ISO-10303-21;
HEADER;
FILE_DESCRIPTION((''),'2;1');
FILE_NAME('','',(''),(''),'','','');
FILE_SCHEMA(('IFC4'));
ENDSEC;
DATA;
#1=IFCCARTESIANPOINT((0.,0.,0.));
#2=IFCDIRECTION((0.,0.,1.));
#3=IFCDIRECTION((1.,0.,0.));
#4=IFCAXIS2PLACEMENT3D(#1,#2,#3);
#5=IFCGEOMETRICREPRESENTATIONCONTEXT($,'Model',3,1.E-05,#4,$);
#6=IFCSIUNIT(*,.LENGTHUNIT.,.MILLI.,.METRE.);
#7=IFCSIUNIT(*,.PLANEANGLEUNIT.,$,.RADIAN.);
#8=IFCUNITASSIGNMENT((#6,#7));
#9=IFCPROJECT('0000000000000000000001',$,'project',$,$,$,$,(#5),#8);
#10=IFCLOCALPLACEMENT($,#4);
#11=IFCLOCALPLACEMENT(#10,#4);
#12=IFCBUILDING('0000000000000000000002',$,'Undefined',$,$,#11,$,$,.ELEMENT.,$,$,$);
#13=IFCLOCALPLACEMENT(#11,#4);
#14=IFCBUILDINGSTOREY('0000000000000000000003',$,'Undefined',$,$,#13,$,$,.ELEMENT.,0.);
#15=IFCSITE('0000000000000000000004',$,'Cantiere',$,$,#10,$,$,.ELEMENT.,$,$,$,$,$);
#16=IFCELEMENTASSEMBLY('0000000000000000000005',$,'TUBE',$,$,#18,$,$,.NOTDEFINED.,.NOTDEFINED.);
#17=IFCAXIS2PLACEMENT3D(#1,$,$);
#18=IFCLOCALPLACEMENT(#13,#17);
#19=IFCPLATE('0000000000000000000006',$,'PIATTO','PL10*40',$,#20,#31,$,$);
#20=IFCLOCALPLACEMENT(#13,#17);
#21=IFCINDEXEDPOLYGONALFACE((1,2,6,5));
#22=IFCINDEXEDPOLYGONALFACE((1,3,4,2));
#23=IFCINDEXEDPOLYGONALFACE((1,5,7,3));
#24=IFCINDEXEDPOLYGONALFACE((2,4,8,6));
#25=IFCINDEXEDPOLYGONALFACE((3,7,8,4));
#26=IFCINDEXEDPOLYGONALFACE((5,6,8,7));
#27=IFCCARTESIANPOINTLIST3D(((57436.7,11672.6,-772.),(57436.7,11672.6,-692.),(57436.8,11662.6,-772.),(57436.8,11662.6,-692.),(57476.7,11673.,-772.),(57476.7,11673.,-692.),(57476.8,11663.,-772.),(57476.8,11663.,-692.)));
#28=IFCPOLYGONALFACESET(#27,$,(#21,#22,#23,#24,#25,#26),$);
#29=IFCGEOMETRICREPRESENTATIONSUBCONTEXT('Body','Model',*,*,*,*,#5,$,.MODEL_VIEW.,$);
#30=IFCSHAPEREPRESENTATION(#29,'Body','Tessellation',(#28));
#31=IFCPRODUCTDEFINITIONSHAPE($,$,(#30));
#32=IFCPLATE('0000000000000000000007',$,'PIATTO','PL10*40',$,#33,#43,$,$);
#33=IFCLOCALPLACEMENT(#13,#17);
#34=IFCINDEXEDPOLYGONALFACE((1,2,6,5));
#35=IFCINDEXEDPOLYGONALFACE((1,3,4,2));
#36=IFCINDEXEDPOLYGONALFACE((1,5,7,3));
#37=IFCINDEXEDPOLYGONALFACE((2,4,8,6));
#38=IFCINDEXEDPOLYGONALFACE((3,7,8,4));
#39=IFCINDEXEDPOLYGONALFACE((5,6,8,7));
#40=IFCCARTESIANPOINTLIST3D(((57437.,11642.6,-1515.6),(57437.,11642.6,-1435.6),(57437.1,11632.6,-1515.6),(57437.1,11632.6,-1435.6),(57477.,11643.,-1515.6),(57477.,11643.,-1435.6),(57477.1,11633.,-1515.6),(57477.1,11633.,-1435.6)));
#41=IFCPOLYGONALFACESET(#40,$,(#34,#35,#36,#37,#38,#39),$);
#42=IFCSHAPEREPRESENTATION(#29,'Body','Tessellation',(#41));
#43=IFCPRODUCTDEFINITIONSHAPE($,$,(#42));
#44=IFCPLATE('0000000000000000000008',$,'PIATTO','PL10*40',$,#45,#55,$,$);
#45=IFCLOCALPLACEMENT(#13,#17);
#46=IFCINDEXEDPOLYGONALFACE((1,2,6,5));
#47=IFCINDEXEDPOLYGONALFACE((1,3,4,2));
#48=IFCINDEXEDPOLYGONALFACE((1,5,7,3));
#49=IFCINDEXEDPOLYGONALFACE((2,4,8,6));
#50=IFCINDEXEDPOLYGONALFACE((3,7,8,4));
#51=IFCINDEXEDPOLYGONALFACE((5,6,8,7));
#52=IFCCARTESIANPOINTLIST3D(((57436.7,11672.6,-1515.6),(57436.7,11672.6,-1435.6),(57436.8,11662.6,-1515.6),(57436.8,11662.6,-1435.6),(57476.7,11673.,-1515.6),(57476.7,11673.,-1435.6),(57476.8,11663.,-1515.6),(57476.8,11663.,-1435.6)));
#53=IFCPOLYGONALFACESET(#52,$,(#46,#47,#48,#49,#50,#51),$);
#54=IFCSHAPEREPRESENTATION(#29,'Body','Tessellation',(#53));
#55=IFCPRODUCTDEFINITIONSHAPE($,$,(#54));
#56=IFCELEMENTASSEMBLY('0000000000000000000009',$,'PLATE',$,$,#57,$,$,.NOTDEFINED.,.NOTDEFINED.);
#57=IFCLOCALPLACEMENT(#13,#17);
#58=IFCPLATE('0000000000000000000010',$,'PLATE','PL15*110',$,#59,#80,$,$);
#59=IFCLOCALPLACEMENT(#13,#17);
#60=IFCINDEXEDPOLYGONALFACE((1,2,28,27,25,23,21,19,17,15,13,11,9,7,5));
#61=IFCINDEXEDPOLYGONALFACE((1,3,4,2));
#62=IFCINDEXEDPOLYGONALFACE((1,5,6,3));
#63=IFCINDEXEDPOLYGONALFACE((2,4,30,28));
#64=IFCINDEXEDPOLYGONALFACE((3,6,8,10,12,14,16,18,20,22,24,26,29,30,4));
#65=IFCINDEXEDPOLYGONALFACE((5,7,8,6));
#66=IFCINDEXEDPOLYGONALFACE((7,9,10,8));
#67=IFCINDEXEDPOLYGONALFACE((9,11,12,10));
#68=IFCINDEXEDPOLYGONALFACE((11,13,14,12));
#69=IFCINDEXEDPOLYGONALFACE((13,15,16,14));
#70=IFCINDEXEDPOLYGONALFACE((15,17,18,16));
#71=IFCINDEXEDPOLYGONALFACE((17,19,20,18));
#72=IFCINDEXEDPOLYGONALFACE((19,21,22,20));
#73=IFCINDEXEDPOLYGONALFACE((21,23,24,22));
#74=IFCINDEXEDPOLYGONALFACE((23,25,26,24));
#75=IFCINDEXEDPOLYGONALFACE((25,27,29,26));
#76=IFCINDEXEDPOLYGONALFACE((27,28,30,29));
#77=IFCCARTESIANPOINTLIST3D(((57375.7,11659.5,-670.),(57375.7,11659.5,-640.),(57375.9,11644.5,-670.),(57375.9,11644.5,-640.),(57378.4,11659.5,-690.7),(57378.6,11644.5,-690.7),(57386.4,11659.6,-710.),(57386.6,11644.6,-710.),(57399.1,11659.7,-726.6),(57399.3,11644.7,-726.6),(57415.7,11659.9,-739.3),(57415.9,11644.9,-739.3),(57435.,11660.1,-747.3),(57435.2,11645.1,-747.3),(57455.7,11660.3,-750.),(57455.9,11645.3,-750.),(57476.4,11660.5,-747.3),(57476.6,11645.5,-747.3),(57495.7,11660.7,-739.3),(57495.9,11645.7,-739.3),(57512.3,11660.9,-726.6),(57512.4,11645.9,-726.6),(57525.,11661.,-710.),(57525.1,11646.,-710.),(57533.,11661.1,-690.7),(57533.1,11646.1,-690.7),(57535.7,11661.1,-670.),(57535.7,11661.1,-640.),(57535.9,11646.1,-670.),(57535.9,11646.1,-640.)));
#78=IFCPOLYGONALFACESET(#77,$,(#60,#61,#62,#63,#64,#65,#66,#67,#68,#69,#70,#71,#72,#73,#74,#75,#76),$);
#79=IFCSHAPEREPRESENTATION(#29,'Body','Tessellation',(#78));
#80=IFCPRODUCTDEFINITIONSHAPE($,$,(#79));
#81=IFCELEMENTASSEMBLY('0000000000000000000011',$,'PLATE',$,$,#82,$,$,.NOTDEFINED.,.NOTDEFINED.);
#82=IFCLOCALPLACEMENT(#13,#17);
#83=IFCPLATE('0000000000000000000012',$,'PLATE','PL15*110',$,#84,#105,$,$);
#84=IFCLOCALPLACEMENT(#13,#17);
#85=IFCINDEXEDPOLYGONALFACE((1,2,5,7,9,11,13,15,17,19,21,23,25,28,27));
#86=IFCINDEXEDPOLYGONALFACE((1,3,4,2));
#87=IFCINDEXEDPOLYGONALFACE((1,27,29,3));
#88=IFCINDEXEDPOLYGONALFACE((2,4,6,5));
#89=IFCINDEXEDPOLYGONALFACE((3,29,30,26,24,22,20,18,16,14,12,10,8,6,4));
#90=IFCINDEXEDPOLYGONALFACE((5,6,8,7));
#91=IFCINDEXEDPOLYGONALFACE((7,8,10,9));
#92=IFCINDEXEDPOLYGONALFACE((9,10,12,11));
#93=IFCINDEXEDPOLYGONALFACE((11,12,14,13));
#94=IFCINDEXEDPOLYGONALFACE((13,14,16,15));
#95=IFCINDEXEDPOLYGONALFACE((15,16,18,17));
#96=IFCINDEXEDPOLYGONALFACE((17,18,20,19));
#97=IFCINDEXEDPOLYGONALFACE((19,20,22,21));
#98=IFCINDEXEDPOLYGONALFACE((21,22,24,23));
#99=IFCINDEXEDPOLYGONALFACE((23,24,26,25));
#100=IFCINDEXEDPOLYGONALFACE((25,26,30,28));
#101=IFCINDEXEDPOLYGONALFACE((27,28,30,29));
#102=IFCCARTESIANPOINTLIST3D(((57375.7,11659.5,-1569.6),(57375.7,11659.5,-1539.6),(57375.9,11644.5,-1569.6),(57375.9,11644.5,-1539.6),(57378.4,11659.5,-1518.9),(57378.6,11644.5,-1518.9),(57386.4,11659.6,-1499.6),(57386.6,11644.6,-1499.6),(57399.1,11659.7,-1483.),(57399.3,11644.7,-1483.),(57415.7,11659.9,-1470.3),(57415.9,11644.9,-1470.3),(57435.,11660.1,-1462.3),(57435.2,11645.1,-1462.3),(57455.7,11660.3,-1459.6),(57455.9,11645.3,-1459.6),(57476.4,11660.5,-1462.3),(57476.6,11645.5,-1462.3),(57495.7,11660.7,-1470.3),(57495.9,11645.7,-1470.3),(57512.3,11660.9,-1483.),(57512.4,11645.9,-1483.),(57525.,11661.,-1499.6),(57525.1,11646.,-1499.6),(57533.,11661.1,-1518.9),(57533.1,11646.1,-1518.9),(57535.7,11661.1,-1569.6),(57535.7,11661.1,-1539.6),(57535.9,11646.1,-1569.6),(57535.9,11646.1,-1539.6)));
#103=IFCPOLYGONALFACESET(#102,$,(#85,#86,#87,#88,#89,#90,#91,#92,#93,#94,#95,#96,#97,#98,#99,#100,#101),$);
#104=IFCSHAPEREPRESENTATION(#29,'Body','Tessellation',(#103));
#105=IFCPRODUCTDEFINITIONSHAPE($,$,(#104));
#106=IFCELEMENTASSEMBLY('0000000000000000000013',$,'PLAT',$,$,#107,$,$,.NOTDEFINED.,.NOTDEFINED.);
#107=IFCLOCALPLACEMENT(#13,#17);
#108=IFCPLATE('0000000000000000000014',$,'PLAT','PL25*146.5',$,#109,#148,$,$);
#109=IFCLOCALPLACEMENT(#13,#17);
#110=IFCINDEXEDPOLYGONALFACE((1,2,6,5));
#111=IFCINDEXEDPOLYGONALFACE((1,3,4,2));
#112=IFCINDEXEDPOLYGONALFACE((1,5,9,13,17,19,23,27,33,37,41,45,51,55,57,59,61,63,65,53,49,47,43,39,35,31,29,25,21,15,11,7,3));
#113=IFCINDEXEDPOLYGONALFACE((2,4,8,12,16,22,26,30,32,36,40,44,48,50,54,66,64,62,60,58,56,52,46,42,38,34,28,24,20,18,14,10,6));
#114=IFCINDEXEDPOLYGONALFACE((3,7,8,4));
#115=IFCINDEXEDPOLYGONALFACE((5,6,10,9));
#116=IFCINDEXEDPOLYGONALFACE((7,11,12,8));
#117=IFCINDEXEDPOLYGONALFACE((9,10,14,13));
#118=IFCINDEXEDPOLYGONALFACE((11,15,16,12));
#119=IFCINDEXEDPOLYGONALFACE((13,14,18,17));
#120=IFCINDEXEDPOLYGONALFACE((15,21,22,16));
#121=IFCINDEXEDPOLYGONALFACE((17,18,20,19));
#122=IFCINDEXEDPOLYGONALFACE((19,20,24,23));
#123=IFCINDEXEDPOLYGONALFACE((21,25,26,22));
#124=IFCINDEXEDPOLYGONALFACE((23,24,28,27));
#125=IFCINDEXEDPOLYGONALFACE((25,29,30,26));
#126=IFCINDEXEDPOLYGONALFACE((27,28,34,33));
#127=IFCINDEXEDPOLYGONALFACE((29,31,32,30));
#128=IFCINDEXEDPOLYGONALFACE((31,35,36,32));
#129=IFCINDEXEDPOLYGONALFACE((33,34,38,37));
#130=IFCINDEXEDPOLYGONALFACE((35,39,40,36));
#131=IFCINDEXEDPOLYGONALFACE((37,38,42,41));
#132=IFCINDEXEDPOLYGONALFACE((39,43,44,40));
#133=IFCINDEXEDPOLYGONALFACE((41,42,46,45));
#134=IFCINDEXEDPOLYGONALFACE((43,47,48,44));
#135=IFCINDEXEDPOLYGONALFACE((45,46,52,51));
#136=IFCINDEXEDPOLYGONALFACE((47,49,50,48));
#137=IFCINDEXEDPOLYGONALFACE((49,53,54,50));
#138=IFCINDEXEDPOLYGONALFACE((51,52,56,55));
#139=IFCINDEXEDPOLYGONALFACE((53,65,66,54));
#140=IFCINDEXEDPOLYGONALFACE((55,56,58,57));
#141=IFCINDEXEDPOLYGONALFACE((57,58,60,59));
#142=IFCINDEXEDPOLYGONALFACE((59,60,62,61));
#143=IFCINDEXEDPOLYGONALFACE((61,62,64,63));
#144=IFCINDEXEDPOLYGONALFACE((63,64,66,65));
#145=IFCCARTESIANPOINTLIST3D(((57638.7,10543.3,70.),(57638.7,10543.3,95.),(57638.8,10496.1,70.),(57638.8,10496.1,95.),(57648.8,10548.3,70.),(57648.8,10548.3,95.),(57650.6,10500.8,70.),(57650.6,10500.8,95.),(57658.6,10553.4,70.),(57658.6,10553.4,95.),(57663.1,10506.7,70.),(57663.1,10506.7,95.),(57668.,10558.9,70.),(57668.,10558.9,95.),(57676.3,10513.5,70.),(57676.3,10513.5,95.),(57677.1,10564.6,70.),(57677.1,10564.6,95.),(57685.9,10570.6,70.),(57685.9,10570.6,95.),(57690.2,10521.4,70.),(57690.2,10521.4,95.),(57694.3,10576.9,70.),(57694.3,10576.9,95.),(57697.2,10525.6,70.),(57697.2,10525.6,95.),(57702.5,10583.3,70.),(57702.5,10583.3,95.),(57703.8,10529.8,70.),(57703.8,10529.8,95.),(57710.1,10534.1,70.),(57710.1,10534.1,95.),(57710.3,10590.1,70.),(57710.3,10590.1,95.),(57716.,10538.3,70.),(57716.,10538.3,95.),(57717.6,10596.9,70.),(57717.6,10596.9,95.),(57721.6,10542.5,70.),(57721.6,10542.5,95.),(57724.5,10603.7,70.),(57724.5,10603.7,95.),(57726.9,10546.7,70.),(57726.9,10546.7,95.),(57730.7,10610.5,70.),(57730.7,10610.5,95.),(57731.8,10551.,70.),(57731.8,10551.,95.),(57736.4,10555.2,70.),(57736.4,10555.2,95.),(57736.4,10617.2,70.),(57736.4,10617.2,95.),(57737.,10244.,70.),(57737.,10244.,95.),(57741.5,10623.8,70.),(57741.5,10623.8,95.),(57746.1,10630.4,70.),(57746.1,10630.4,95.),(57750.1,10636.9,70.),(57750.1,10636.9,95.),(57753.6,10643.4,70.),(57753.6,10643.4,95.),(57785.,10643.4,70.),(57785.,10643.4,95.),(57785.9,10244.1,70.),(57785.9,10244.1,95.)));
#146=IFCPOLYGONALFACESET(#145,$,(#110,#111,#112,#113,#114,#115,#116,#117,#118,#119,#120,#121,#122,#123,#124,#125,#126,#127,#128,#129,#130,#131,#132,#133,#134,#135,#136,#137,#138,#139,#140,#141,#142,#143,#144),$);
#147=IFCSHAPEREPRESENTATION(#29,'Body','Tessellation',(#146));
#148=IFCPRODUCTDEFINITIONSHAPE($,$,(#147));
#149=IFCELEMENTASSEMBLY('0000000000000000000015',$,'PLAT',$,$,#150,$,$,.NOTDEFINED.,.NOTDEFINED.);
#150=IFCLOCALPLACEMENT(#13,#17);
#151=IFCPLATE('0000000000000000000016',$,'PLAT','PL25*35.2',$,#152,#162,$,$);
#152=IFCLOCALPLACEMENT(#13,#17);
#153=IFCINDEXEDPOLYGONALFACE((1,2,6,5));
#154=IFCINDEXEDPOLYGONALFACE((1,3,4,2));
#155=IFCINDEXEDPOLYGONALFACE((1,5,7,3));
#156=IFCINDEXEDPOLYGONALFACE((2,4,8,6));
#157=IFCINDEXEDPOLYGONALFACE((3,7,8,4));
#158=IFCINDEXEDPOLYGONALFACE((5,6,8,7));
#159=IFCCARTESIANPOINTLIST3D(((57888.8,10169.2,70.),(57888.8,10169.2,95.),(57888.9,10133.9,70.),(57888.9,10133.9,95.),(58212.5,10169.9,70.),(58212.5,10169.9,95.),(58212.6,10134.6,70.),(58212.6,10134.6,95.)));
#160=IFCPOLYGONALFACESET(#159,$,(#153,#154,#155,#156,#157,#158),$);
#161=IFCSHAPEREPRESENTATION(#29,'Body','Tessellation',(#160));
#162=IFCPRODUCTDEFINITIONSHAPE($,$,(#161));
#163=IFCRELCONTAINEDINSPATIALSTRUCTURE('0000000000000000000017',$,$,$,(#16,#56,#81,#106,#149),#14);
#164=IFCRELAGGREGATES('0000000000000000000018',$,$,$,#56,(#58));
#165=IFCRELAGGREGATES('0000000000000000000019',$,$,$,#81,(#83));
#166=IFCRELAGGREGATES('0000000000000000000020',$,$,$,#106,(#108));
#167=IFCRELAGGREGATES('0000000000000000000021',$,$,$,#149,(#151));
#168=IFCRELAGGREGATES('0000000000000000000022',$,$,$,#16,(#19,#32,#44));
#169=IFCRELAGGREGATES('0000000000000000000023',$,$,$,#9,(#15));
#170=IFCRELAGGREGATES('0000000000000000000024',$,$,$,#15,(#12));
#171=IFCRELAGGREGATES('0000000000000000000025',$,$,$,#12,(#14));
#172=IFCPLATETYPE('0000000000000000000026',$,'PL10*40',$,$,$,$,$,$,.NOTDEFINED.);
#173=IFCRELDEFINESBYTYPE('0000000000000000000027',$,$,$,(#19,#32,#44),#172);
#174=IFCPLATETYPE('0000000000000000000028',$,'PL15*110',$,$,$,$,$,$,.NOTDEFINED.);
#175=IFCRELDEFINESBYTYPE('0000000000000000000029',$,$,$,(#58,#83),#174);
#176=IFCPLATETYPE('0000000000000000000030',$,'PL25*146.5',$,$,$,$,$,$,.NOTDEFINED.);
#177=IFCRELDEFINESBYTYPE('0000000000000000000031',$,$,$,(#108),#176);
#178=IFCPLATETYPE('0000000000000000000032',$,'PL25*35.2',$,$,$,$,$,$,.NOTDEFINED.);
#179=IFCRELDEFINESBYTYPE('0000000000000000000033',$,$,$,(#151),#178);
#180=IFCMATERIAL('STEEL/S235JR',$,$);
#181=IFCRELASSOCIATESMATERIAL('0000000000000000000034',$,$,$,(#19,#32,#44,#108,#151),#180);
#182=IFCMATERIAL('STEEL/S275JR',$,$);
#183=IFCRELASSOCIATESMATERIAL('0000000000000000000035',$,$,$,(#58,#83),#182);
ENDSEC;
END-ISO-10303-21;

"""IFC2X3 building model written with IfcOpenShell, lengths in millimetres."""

from ifc_helpers import new_model, si_unit, frame, frame_2d, origin_with_axes, place, context, subcontext, project, spatial, polyline, circle_curve, parameter, trimmed, segment, composite_curve, outline, extrude, material, type_object, element, aggregate, save


model = new_model("IFC2X3")

# Units and contexts
model_context = context("Model", 3, precision=1e-05, world=origin_with_axes())
body_context = subcontext(model_context, "Body", "Model", "MODEL_VIEW")
ifc_project = project(units=[si_unit("LENGTHUNIT", "METRE", prefix="MILLI"), si_unit("PLANEANGLEUNIT", "RADIAN")], contexts=[model_context])

# Site, building, storey
site_placement = place(None, origin_with_axes())
site = spatial("IfcSite", under=ifc_project, at=site_placement, Name="Cantiere", CompositionType="ELEMENT")
building_placement = place(site_placement, origin_with_axes())
building = spatial("IfcBuilding", under=site, at=building_placement, Name="Undefined", CompositionType="ELEMENT")
storey_placement = place(building_placement, origin_with_axes())
storey = spatial("IfcBuildingStorey", under=building, at=storey_placement, Name="Undefined", CompositionType="ELEMENT", Elevation=0.0)

# Element assembly
assembly_1_placement = place(storey_placement, origin_with_axes())
assembly_1 = element("IfcElementAssembly", 1, at=assembly_1_placement, inside=storey, Name="TUBE", AssemblyPlace="NOTDEFINED", PredefinedType="NOTDEFINED")
ifc_material_1 = material(Name="STEEL/S235JR")

# Plates
plate_type_1 = type_object("IfcPlateType", Name="PL10*40", PredefinedType="NOTDEFINED")
plate_1_placement = place(assembly_1_placement, frame((57476.8, 11668.0, -772.0), z_axis=(0.01014, -0.999949, 0.0), x_axis=(0.0, 0.0, 1.0)))
plate_1 = element("IfcPlate", 2, at=plate_1_placement, type_object=plate_type_1, material=ifc_material_1, Name="PIATTO", Description="PL10*40", context=body_context, shape_type="SweptSolid", body=[
    extrude(outline(polyline([(0.0, 0.0), (80.0, 0.0), (80.0, 40.0), (0.0, 40.0), (0.0, 0.0)])), frame((0.0, 0.0, -5.0), z_axis=(0.0, 0.0, 1.0), x_axis=(1.0, 0.0, 0.0)), (0.0, 0.0, 1.0), 10.0),
])
plate_2_placement = place(assembly_1_placement, frame((57437.1, 11637.6, -1435.6), z_axis=(0.01014, -0.999949, 0.0), x_axis=(0.0, 0.000001, -1.0)))
plate_2 = element("IfcPlate", 3, at=plate_2_placement, type_object=plate_type_1, material=ifc_material_1, Name="PIATTO", Description="PL10*40", context=body_context, shape_type="SweptSolid", body=[
    extrude(outline(polyline([(0.0, 0.0), (80.0, 0.0), (80.0, 40.0), (0.0, 40.0), (0.0, 0.0)])), frame((0.0, 0.0, -5.0), z_axis=(0.0, 0.0, 1.0), x_axis=(1.0, 0.0, 0.0)), (0.0, 0.0, 1.0), 10.0),
])
plate_3_placement = place(assembly_1_placement, frame((57436.8, 11667.6, -1435.6), z_axis=(0.01014, -0.999949, 0.0), x_axis=(0.0, 0.000001, -1.0)))
plate_3 = element("IfcPlate", 4, at=plate_3_placement, type_object=plate_type_1, material=ifc_material_1, Name="PIATTO", Description="PL10*40", context=body_context, shape_type="SweptSolid", body=[
    extrude(outline(polyline([(0.0, 0.0), (80.0, 0.0), (80.0, 40.0), (0.0, 40.0), (0.0, 0.0)])), frame((0.0, 0.0, -5.0), z_axis=(0.0, 0.0, 1.0), x_axis=(1.0, 0.0, 0.0)), (0.0, 0.0, 1.0), 10.0),
])

# Element assemblies, plates
assembly_2_placement = place(storey_placement, origin_with_axes())
assembly_2 = element("IfcElementAssembly", 5, at=assembly_2_placement, inside=storey, Name="PLATE", AssemblyPlace="NOTDEFINED", PredefinedType="NOTDEFINED")
ifc_material_2 = material(Name="STEEL/S275JR")
plate_type_2 = type_object("IfcPlateType", Name="PL15*110", PredefinedType="NOTDEFINED")
plate_4_placement = place(assembly_2_placement, frame((57375.8, 11652.0, -640.0), z_axis=(-0.010139, 0.999949, 0.0), x_axis=(0.999949, 0.010139, 0.0)))
plate_4 = element("IfcPlate", 6, at=plate_4_placement, type_object=plate_type_2, material=ifc_material_2, Name="PLATE", Description="PL15*110", context=body_context, shape_type="SweptSolid", body=[
    extrude(outline(composite_curve([segment(polyline([(0.0, 0.0), (160.0, 0.0), (160.0, 30.0)]), True, "CONTINUOUS"), segment(trimmed(circle_curve(frame_2d((80.0, 30.0), x_axis=(1.0, 0.0)), 80.0), [parameter(0.0)], [parameter(1.570796)], True, "PARAMETER"), True, "CONTINUOUS"), segment(trimmed(circle_curve(frame_2d((80.0, 30.0), x_axis=(0.0, 1.0)), 80.0), [parameter(0.0)], [parameter(1.570796)], True, "PARAMETER"), True, "CONTINUOUS"), segment(polyline([(0.0, 30.0), (0.0, 0.0)]), True, "CONTINUOUS")], self_intersect=True)), frame((0.0, 0.0, -7.5), z_axis=(0.0, 0.0, 1.0), x_axis=(1.0, 0.0, 0.0)), (0.0, 0.0, 1.0), 15.0),
])
aggregate(assembly_2, [plate_4])
assembly_3_placement = place(storey_placement, origin_with_axes())
assembly_3 = element("IfcElementAssembly", 7, at=assembly_3_placement, inside=storey, Name="PLATE", AssemblyPlace="NOTDEFINED", PredefinedType="NOTDEFINED")
plate_5_placement = place(assembly_3_placement, frame((57375.8, 11652.0, -1569.6), z_axis=(0.010138, -0.999949, 0.0), x_axis=(0.999949, 0.010139, 0.0)))
plate_5 = element("IfcPlate", 8, at=plate_5_placement, type_object=plate_type_2, material=ifc_material_2, Name="PLATE", Description="PL15*110", context=body_context, shape_type="SweptSolid", body=[
    extrude(outline(composite_curve([segment(polyline([(0.0, 0.0), (160.0, 0.0), (160.0, 30.0)]), True, "CONTINUOUS"), segment(trimmed(circle_curve(frame_2d((80.0, 30.0), x_axis=(1.0, 0.0)), 80.0), [parameter(0.0)], [parameter(1.570796)], True, "PARAMETER"), True, "CONTINUOUS"), segment(trimmed(circle_curve(frame_2d((80.0, 30.0), x_axis=(0.0, 1.0)), 80.0), [parameter(0.0)], [parameter(1.570796)], True, "PARAMETER"), True, "CONTINUOUS"), segment(polyline([(0.0, 30.0), (0.0, 0.0)]), True, "CONTINUOUS")], self_intersect=True)), frame((0.0, 0.0, -7.5), z_axis=(0.0, 0.0, 1.0), x_axis=(1.0, 0.0, 0.0)), (0.0, 0.0, 1.0), 15.0),
])
aggregate(assembly_3, [plate_5])
assembly_4_placement = place(storey_placement, origin_with_axes())
assembly_4 = element("IfcElementAssembly", 9, at=assembly_4_placement, inside=storey, Name="PLAT", AssemblyPlace="NOTDEFINED", PredefinedType="NOTDEFINED")
plate_type_3 = type_object("IfcPlateType", Name="PL25*146.5", PredefinedType="NOTDEFINED")
plate_6_placement = place(assembly_4_placement, frame((57785.9, 10244.1, 82.5), z_axis=(0.0, 0.000001, -1.0), x_axis=(-0.999998, -0.00212, 0.0)))
plate_6 = element("IfcPlate", 10, at=plate_6_placement, type_object=plate_type_3, material=ifc_material_1, Name="PLAT", Description="PL25*146.5", context=body_context, shape_type="SweptSolid", body=[
    extrude(outline(polyline([(0.0, 0.0), (48.9, 0.0), (48.9, 311.2), (53.5, 307.0), (58.4, 302.7), (63.6, 298.6), (69.2, 294.3), (75.1, 290.1), (81.5, 285.9), (88.1, 281.7), (95.1, 277.5), (109.0, 269.6), (122.3, 262.8), (134.8, 257.0), (146.5, 252.3), (146.5, 299.5), (136.4, 304.5), (126.7, 309.6), (117.2, 315.1), (108.1, 320.7), (99.3, 326.7), (90.9, 333.0), (82.7, 339.4), (74.9, 346.2), (67.5, 353.0), (60.6, 359.8), (54.4, 366.5), (48.7, 373.2), (43.5, 379.8), (39.0, 386.4), (34.9, 392.9), (31.5, 399.3), (0.0, 399.3), (0.0, 0.0)])), frame((0.0, 0.0, -12.5), z_axis=(0.0, 0.0, 1.0), x_axis=(1.0, 0.0, 0.0)), (0.0, 0.0, 1.0), 25.0),
])
aggregate(assembly_4, [plate_6])
assembly_5_placement = place(storey_placement, origin_with_axes())
assembly_5 = element("IfcElementAssembly", 11, at=assembly_5_placement, inside=storey, Name="PLAT", AssemblyPlace="NOTDEFINED", PredefinedType="NOTDEFINED")
plate_type_4 = type_object("IfcPlateType", Name="PL25*35.2", PredefinedType="NOTDEFINED")
plate_7_placement = place(assembly_5_placement, frame((57888.9, 10133.9, 82.5), z_axis=(0.0, 0.000001, -1.0), x_axis=(-0.00212, 0.999998, 0.0)))
plate_7 = element("IfcPlate", 12, at=plate_7_placement, type_object=plate_type_4, material=ifc_material_1, Name="PLAT", Description="PL25*35.2", context=body_context, shape_type="SweptSolid", body=[
    extrude(outline(polyline([(0.0, 0.0), (35.2, 0.0), (35.2, 323.7), (0.0, 323.7), (0.0, 0.0)])), frame((0.0, 0.0, -12.5), z_axis=(0.0, 0.0, 1.0), x_axis=(1.0, 0.0, 0.0)), (0.0, 0.0, 1.0), 25.0),
])
aggregate(assembly_5, [plate_7])

aggregate(assembly_1, [plate_1, plate_2, plate_3])

save(model, "model.ifc")
